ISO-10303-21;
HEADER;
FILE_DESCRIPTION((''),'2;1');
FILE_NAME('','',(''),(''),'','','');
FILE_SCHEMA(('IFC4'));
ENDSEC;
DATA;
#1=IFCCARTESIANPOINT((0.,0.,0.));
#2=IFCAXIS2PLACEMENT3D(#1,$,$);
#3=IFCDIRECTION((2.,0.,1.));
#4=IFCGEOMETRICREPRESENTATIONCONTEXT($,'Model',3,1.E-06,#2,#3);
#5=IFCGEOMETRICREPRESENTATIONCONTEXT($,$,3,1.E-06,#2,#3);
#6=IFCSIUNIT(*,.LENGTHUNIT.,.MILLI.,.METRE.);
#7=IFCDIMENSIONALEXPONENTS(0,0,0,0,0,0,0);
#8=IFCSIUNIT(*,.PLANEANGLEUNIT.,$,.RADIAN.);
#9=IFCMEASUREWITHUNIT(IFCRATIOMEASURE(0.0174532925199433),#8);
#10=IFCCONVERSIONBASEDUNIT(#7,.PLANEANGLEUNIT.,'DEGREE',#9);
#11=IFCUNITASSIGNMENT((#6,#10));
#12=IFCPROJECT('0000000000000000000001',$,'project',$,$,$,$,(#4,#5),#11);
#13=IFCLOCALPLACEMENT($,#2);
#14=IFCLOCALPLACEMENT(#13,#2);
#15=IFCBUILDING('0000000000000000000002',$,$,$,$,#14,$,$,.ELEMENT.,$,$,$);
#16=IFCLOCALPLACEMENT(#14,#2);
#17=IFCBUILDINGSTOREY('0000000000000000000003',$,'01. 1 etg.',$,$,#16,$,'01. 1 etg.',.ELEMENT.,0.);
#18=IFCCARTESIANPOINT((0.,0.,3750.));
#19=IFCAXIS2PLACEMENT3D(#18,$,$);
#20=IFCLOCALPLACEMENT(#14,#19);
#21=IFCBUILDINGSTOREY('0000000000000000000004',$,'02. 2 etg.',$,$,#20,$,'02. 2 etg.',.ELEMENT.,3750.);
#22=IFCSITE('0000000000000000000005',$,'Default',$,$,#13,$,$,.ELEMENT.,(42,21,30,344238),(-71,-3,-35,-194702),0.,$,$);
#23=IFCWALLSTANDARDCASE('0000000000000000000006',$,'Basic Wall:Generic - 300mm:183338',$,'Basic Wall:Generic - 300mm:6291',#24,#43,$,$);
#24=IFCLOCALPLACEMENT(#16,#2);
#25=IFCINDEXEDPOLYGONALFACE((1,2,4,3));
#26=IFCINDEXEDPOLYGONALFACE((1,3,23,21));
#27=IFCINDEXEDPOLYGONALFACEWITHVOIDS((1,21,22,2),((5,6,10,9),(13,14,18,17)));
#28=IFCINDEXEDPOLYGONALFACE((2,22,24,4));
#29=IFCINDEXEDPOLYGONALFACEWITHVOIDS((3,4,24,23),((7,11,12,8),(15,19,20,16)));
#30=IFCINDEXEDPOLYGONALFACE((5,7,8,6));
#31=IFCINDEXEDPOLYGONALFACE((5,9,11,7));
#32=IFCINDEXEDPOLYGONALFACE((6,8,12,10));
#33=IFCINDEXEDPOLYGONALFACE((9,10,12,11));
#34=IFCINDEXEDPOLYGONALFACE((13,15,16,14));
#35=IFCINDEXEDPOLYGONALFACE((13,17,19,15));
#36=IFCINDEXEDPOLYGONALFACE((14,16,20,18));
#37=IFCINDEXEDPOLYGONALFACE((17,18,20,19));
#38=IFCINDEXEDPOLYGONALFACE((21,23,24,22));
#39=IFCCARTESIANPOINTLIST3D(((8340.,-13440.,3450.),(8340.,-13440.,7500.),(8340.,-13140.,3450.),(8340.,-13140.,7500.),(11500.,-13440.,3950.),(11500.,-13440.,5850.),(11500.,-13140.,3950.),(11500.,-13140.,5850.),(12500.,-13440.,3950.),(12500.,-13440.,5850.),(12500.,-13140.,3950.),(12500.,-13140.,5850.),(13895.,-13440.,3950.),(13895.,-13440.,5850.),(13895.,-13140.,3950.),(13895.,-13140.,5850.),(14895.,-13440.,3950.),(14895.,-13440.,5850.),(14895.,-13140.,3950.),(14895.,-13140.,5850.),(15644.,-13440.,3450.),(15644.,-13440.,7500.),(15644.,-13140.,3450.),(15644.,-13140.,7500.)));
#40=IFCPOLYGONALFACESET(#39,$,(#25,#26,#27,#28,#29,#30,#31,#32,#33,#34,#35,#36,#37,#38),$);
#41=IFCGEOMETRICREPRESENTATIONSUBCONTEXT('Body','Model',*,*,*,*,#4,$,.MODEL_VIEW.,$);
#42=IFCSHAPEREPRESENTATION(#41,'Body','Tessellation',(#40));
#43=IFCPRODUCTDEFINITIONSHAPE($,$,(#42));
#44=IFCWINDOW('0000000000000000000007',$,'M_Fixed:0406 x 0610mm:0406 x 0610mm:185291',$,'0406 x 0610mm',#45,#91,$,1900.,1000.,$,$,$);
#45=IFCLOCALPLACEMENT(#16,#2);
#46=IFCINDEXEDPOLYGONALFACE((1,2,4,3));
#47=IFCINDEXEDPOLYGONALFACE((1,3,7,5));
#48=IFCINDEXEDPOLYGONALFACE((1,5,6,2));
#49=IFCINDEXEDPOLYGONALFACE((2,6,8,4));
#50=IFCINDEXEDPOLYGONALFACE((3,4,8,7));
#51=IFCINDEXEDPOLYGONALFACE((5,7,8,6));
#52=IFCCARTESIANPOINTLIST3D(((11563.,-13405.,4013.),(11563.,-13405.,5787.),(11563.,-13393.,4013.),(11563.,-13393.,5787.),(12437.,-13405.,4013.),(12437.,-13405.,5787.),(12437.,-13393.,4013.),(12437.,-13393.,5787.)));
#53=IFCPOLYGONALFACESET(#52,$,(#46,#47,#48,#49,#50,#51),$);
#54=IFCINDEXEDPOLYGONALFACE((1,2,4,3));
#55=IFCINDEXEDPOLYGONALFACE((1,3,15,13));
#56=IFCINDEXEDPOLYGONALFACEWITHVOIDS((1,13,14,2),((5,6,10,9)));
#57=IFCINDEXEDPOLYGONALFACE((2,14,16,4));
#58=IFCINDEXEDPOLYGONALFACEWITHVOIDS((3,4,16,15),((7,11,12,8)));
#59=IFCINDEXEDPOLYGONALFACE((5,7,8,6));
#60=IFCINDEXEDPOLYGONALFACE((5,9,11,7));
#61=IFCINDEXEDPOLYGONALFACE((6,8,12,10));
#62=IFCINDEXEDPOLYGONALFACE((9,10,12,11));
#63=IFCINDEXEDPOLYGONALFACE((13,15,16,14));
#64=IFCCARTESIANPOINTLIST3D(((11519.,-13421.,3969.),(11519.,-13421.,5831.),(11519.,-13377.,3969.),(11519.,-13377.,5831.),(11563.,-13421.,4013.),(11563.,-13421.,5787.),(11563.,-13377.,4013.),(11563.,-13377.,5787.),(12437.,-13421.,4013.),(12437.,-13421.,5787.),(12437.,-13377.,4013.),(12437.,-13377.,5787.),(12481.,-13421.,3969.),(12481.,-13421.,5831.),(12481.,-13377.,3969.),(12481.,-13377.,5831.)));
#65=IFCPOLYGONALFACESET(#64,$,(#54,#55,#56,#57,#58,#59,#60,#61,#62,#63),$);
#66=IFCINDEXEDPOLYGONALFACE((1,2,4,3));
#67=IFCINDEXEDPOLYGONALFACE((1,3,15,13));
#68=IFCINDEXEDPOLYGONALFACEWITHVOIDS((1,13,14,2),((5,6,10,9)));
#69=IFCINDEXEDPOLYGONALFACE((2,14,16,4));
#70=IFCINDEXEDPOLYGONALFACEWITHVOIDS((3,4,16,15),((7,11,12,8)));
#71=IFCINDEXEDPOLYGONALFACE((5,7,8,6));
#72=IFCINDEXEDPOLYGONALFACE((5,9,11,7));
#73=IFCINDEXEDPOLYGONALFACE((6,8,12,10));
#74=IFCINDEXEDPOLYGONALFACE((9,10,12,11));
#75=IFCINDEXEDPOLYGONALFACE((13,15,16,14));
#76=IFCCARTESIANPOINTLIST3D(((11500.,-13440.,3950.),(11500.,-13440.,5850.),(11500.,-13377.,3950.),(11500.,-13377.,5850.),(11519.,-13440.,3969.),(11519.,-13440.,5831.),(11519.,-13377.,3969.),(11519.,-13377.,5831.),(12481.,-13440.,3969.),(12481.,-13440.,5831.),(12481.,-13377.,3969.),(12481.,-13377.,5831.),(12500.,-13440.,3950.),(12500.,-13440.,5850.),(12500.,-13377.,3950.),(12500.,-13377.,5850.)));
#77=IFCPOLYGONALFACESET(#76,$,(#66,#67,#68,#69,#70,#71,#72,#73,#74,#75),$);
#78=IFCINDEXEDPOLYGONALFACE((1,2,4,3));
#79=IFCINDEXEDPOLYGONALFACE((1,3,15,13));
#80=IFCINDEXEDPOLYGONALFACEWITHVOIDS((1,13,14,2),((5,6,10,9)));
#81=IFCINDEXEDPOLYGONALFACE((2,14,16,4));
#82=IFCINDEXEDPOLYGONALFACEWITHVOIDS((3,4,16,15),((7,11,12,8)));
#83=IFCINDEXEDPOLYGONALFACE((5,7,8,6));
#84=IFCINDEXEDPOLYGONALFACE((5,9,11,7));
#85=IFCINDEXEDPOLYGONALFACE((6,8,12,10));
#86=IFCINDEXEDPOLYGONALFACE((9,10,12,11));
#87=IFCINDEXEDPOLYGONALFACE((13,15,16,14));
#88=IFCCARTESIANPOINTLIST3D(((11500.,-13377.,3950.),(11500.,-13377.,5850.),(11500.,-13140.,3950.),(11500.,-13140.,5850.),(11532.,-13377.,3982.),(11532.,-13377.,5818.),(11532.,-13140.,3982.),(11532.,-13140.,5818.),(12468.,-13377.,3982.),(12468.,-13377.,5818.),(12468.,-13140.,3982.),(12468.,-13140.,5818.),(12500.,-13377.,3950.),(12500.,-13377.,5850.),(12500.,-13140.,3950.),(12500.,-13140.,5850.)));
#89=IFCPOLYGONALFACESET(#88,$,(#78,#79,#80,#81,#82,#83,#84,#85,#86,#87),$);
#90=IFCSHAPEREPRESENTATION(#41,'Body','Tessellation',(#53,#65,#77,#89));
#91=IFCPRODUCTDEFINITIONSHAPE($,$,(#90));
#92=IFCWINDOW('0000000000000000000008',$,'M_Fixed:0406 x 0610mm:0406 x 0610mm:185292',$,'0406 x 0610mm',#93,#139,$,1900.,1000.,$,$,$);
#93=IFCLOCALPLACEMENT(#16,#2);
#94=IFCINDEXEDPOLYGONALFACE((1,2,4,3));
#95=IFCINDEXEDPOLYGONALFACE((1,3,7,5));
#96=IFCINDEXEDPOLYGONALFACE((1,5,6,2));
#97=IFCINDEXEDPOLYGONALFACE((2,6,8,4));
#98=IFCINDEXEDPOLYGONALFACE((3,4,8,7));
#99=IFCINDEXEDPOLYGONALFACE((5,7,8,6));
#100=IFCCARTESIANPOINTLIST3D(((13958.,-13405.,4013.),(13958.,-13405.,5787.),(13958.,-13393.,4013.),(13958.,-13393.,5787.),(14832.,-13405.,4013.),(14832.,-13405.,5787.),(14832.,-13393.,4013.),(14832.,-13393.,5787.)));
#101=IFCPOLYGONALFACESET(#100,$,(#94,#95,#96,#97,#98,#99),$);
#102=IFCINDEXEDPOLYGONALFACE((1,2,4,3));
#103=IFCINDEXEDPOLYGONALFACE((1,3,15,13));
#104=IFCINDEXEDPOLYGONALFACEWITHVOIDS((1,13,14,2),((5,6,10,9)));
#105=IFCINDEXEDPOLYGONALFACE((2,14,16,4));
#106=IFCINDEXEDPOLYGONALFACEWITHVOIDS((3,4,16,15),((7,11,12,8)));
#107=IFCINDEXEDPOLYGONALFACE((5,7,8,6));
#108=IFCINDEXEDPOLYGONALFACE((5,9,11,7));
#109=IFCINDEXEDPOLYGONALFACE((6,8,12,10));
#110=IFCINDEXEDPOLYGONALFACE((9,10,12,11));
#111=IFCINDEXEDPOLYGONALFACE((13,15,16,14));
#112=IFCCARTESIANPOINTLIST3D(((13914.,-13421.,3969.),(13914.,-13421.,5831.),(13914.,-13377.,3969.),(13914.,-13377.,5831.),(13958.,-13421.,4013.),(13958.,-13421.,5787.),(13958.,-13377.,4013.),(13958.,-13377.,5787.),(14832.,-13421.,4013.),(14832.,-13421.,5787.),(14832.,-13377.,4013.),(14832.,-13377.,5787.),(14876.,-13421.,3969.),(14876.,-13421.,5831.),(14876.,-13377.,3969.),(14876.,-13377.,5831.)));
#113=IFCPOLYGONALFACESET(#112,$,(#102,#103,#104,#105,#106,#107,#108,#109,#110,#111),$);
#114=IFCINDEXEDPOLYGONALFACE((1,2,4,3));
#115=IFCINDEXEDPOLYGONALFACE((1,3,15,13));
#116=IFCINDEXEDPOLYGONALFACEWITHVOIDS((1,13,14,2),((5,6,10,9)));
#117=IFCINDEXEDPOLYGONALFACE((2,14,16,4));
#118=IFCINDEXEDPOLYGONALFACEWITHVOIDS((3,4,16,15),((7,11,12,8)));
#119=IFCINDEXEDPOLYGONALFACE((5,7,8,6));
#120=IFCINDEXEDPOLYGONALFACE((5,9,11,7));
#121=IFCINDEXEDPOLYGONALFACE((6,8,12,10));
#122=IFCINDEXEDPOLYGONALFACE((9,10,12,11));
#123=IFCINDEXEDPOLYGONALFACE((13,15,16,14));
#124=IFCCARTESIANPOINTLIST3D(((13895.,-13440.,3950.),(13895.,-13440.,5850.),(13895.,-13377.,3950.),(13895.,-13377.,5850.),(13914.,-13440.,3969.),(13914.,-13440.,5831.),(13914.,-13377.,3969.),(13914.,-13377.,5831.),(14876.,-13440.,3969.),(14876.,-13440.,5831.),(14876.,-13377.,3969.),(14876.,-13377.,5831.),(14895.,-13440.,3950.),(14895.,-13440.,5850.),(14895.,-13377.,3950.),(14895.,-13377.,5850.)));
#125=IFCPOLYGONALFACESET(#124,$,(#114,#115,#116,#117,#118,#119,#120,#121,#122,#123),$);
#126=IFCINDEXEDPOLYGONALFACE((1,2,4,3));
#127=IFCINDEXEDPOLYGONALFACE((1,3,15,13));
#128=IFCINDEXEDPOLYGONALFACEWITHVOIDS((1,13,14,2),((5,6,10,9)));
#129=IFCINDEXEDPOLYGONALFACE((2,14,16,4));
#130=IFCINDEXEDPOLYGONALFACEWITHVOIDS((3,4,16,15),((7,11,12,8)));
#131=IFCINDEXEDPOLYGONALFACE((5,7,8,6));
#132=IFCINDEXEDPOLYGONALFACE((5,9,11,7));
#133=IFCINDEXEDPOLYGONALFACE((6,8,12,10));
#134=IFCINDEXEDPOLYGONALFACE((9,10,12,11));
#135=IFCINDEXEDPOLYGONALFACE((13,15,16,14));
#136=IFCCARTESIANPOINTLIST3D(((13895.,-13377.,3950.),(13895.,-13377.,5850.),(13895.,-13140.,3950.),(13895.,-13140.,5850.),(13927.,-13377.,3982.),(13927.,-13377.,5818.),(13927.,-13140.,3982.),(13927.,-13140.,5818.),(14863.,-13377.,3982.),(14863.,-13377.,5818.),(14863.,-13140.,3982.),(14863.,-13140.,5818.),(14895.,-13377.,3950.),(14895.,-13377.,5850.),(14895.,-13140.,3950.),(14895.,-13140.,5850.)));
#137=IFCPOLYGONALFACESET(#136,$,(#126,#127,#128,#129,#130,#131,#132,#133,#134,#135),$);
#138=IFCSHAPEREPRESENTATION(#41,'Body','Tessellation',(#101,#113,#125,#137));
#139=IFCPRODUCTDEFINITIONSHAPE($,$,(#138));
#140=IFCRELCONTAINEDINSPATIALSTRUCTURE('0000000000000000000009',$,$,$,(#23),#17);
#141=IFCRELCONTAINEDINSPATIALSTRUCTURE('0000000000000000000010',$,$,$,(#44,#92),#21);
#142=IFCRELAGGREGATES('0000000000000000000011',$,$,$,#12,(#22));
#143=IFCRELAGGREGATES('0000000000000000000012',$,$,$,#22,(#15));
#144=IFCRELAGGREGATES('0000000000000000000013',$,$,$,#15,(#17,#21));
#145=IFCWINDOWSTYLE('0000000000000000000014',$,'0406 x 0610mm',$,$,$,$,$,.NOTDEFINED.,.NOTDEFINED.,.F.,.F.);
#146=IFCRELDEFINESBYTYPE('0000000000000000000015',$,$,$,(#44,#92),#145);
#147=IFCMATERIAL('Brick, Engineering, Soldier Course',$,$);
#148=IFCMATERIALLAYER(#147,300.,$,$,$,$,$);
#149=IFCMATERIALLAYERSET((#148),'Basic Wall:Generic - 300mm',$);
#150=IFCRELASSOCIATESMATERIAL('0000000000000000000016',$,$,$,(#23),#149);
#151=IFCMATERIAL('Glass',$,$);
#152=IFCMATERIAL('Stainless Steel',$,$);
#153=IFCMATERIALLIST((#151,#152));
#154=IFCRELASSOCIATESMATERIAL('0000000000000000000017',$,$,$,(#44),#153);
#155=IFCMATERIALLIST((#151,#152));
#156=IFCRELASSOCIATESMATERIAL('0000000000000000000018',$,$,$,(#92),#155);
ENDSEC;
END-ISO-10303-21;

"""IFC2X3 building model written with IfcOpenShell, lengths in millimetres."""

from ifc_helpers import new_model, entity, si_unit, converted_unit, direction, frame, frame_2d, origin, origin_2d_with_axis, place, context, subcontext, project, spatial, polyline, rectangle, outline, extrude, source, transform, mapped, material, material_list, layer, layer_set, layer_usage, type_object, type_shapes, element, fill, save


model = new_model("IFC2X3")

# Units and contexts
model_context = context("Model", 3, precision=1e-06, world=origin(), true_north=direction((2.0, 0.0, 1.0)))
context_of_model = context(None, 3, precision=1e-06, world=origin(), true_north=direction((2.0, 0.0, 1.0)))
body_context = subcontext(model_context, "Body", "Model", "MODEL_VIEW")
ifc_project = project(units=[si_unit("LENGTHUNIT", "METRE", prefix="MILLI"), converted_unit("PLANEANGLEUNIT", "DEGREE", entity("IfcRatioMeasure", 0.0174532925199433), si_unit("PLANEANGLEUNIT", "RADIAN"), dimensions=[0, 0, 0, 0, 0, 0, 0])], contexts=[model_context, context_of_model])

# Site, building, storey
site_placement = place(None, origin())
site = spatial("IfcSite", under=ifc_project, at=site_placement, Name="Default", CompositionType="ELEMENT", RefLatitude=(42, 21, 30, 344238), RefLongitude=(-71, -3, -35, -194702), RefElevation=0.0)
building_placement = place(site_placement, origin())
building = spatial("IfcBuilding", under=site, at=building_placement, CompositionType="ELEMENT")
storey_1_placement = place(building_placement, origin())
storey_1 = spatial("IfcBuildingStorey", under=building, at=storey_1_placement, Name="01. 1 etg.", LongName="01. 1 etg.", CompositionType="ELEMENT", Elevation=0.0)

# Shared definitions
ifc_material_1 = material(Name="Brick, Engineering, Soldier Course")
ifc_layer_1 = layer(ifc_material_1, 300.0)
ifc_layer_set_1 = layer_set([ifc_layer_1], Name="Basic Wall:Generic - 300mm")
ifc_material_2 = material(Name="Glass")
ifc_material_3 = material(Name="Stainless Steel")
window_style = type_object("IfcWindowStyle", Name="0406 x 0610mm", ConstructionType="NOTDEFINED", OperationType="NOTDEFINED", ParameterTakesPrecedence=False, Sizeable=False)
shared_shape_1 = source(origin(), body_context, "Body", "SweptSolid", [
    extrude(rectangle(XDim=12.0, YDim=874.0, at=frame_2d((0.0, 0.0), x_axis=(1.0, 0.0))), frame((500.0, 259.0, 63.0), z_axis=(0.0, 0.0, 1.0), x_axis=(0.0, -1.0, 0.0)), (0.0, 0.0, 1.0), 1774.0),
    extrude(outline(polyline([(-481.0, -931.0), (481.0, -931.0), (481.0, 931.0), (-481.0, 931.0), (-481.0, -931.0)]), holes=[polyline([(-437.0, -887.0), (-437.0, 887.0), (437.0, 887.0), (437.0, -887.0), (-437.0, -887.0)])]), frame((500.0, 237.0, 950.0), z_axis=(0.0, 1.0, 0.0), x_axis=(1.0, 0.0, 0.0)), (0.0, 0.0, 1.0), 44.0),
    extrude(outline(polyline([(-500.0, -950.0), (500.0, -950.0), (500.0, 950.0), (-500.0, 950.0), (-500.0, -950.0)]), holes=[polyline([(-481.0, -931.0), (-481.0, 931.0), (481.0, 931.0), (481.0, -931.0), (-481.0, -931.0)])]), frame((500.0, 237.0, 950.0), z_axis=(0.0, 1.0, 0.0), x_axis=(1.0, 0.0, 0.0)), (0.0, 0.0, 1.0), 63.0),
    extrude(outline(polyline([(-500.0, -950.0), (500.0, -950.0), (500.0, 950.0), (-500.0, 950.0), (-500.0, -950.0)]), holes=[polyline([(-468.0, -918.0), (-468.0, 918.0), (468.0, 918.0), (468.0, -918.0), (-468.0, -918.0)])]), frame((500.0, 0.0, 950.0), z_axis=(0.0, 1.0, 0.0), x_axis=(1.0, 0.0, 0.0)), (0.0, 0.0, 1.0), 237.0),
])
type_shapes(window_style, [shared_shape_1])

# Wall, openings
ifc_layer_usage_1 = layer_usage(ifc_layer_set_1, "AXIS2", "POSITIVE", -150.0)
wall_1_placement = place(storey_1_placement, frame((8340.0, -13290.0, 3450.0)))
wall_1 = element("IfcWallStandardCase", 1, at=wall_1_placement, inside=storey_1, material=ifc_layer_usage_1, Name="Basic Wall:Generic - 300mm:183338", ObjectType="Basic Wall:Generic - 300mm:6291", context=body_context, shape_type="SweptSolid", body=[
    extrude(rectangle(XDim=7304.0, YDim=300.0, at=frame_2d((3652.0, 0.0), x_axis=(-1.0, 0.0))), origin(), (0.0, 0.0, 1.0), 4050.0),
])
opening_1_placement = place(wall_1_placement, origin())
element("IfcOpeningElement", 2, at=opening_1_placement, cuts=wall_1, ObjectType="Opening", context=body_context, shape_type="SweptSolid", body=[
    extrude(rectangle(XDim=7500.0, YDim=9374.2, at=origin_2d_with_axis()), frame((11991.1, -302.4, 300.0), z_axis=(0.0, 1.0, 0.0), x_axis=(0.0, 0.0, 1.0)), (0.0, 0.0, 1.0), 604.8),
])
opening_2_placement = place(wall_1_placement, frame((3160.0, -150.0, 500.0)))
opening_2 = element("IfcOpeningElement", 3, at=opening_2_placement, cuts=wall_1, ObjectType="Opening", context=body_context, shape_type="SweptSolid", body=[
    extrude(rectangle(XDim=1900.0, YDim=1000.0, at=frame_2d((950.0, 500.0), x_axis=(1.0, 0.0))), frame((0.0, 0.0, 0.0), z_axis=(0.0, 1.0, 0.0), x_axis=(0.0, 0.0, 1.0)), (0.0, 0.0, 1.0), 300.0),
])
opening_3_placement = place(wall_1_placement, frame((5555.0, -150.0, 500.0)))
opening_3 = element("IfcOpeningElement", 4, at=opening_3_placement, cuts=wall_1, ObjectType="Opening", context=body_context, shape_type="SweptSolid", body=[
    extrude(rectangle(XDim=1900.0, YDim=1000.0, at=frame_2d((950.0, 500.0), x_axis=(1.0, 0.0))), frame((0.0, 0.0, 0.0), z_axis=(0.0, 1.0, 0.0), x_axis=(0.0, 0.0, 1.0)), (0.0, 0.0, 1.0), 300.0),
])

# Shared definitions
storey_2_placement = place(building_placement, frame((0.0, 0.0, 3750.0)))
storey_2 = spatial("IfcBuildingStorey", under=building, at=storey_2_placement, Name="02. 2 etg.", LongName="02. 2 etg.", CompositionType="ELEMENT", Elevation=3750.0)

# Windows
ifc_material_list_1 = material_list([ifc_material_2, ifc_material_3])
window_1_placement = place(opening_2_placement, frame((1000.0, 300.0, 0.0), z_axis=(0.0, 0.0, 1.0), x_axis=(-1.0, 0.0, 0.0)))
window_1 = element("IfcWindow", 5, at=window_1_placement, inside=storey_2, type_object=window_style, material=ifc_material_list_1, Name="M_Fixed:0406 x 0610mm:0406 x 0610mm:185291", ObjectType="0406 x 0610mm", OverallHeight=1900.0, OverallWidth=1000.0, context=body_context, shape_type="MappedRepresentation", body=[
    mapped(shared_shape_1, transform((0.0, 0.0, 0.0), scale=1.0)),
])
fill(opening_2, window_1)
ifc_material_list_2 = material_list([ifc_material_2, ifc_material_3])
window_2_placement = place(opening_3_placement, frame((1000.0, 300.0, 0.0), z_axis=(0.0, 0.0, 1.0), x_axis=(-1.0, 0.0, 0.0)))
window_2 = element("IfcWindow", 6, at=window_2_placement, inside=storey_2, type_object=window_style, material=ifc_material_list_2, Name="M_Fixed:0406 x 0610mm:0406 x 0610mm:185292", ObjectType="0406 x 0610mm", OverallHeight=1900.0, OverallWidth=1000.0, context=body_context, shape_type="MappedRepresentation", body=[
    mapped(shared_shape_1, transform((0.0, 0.0, 0.0), scale=1.0)),
])
fill(opening_3, window_2)

save(model, "model.ifc")
